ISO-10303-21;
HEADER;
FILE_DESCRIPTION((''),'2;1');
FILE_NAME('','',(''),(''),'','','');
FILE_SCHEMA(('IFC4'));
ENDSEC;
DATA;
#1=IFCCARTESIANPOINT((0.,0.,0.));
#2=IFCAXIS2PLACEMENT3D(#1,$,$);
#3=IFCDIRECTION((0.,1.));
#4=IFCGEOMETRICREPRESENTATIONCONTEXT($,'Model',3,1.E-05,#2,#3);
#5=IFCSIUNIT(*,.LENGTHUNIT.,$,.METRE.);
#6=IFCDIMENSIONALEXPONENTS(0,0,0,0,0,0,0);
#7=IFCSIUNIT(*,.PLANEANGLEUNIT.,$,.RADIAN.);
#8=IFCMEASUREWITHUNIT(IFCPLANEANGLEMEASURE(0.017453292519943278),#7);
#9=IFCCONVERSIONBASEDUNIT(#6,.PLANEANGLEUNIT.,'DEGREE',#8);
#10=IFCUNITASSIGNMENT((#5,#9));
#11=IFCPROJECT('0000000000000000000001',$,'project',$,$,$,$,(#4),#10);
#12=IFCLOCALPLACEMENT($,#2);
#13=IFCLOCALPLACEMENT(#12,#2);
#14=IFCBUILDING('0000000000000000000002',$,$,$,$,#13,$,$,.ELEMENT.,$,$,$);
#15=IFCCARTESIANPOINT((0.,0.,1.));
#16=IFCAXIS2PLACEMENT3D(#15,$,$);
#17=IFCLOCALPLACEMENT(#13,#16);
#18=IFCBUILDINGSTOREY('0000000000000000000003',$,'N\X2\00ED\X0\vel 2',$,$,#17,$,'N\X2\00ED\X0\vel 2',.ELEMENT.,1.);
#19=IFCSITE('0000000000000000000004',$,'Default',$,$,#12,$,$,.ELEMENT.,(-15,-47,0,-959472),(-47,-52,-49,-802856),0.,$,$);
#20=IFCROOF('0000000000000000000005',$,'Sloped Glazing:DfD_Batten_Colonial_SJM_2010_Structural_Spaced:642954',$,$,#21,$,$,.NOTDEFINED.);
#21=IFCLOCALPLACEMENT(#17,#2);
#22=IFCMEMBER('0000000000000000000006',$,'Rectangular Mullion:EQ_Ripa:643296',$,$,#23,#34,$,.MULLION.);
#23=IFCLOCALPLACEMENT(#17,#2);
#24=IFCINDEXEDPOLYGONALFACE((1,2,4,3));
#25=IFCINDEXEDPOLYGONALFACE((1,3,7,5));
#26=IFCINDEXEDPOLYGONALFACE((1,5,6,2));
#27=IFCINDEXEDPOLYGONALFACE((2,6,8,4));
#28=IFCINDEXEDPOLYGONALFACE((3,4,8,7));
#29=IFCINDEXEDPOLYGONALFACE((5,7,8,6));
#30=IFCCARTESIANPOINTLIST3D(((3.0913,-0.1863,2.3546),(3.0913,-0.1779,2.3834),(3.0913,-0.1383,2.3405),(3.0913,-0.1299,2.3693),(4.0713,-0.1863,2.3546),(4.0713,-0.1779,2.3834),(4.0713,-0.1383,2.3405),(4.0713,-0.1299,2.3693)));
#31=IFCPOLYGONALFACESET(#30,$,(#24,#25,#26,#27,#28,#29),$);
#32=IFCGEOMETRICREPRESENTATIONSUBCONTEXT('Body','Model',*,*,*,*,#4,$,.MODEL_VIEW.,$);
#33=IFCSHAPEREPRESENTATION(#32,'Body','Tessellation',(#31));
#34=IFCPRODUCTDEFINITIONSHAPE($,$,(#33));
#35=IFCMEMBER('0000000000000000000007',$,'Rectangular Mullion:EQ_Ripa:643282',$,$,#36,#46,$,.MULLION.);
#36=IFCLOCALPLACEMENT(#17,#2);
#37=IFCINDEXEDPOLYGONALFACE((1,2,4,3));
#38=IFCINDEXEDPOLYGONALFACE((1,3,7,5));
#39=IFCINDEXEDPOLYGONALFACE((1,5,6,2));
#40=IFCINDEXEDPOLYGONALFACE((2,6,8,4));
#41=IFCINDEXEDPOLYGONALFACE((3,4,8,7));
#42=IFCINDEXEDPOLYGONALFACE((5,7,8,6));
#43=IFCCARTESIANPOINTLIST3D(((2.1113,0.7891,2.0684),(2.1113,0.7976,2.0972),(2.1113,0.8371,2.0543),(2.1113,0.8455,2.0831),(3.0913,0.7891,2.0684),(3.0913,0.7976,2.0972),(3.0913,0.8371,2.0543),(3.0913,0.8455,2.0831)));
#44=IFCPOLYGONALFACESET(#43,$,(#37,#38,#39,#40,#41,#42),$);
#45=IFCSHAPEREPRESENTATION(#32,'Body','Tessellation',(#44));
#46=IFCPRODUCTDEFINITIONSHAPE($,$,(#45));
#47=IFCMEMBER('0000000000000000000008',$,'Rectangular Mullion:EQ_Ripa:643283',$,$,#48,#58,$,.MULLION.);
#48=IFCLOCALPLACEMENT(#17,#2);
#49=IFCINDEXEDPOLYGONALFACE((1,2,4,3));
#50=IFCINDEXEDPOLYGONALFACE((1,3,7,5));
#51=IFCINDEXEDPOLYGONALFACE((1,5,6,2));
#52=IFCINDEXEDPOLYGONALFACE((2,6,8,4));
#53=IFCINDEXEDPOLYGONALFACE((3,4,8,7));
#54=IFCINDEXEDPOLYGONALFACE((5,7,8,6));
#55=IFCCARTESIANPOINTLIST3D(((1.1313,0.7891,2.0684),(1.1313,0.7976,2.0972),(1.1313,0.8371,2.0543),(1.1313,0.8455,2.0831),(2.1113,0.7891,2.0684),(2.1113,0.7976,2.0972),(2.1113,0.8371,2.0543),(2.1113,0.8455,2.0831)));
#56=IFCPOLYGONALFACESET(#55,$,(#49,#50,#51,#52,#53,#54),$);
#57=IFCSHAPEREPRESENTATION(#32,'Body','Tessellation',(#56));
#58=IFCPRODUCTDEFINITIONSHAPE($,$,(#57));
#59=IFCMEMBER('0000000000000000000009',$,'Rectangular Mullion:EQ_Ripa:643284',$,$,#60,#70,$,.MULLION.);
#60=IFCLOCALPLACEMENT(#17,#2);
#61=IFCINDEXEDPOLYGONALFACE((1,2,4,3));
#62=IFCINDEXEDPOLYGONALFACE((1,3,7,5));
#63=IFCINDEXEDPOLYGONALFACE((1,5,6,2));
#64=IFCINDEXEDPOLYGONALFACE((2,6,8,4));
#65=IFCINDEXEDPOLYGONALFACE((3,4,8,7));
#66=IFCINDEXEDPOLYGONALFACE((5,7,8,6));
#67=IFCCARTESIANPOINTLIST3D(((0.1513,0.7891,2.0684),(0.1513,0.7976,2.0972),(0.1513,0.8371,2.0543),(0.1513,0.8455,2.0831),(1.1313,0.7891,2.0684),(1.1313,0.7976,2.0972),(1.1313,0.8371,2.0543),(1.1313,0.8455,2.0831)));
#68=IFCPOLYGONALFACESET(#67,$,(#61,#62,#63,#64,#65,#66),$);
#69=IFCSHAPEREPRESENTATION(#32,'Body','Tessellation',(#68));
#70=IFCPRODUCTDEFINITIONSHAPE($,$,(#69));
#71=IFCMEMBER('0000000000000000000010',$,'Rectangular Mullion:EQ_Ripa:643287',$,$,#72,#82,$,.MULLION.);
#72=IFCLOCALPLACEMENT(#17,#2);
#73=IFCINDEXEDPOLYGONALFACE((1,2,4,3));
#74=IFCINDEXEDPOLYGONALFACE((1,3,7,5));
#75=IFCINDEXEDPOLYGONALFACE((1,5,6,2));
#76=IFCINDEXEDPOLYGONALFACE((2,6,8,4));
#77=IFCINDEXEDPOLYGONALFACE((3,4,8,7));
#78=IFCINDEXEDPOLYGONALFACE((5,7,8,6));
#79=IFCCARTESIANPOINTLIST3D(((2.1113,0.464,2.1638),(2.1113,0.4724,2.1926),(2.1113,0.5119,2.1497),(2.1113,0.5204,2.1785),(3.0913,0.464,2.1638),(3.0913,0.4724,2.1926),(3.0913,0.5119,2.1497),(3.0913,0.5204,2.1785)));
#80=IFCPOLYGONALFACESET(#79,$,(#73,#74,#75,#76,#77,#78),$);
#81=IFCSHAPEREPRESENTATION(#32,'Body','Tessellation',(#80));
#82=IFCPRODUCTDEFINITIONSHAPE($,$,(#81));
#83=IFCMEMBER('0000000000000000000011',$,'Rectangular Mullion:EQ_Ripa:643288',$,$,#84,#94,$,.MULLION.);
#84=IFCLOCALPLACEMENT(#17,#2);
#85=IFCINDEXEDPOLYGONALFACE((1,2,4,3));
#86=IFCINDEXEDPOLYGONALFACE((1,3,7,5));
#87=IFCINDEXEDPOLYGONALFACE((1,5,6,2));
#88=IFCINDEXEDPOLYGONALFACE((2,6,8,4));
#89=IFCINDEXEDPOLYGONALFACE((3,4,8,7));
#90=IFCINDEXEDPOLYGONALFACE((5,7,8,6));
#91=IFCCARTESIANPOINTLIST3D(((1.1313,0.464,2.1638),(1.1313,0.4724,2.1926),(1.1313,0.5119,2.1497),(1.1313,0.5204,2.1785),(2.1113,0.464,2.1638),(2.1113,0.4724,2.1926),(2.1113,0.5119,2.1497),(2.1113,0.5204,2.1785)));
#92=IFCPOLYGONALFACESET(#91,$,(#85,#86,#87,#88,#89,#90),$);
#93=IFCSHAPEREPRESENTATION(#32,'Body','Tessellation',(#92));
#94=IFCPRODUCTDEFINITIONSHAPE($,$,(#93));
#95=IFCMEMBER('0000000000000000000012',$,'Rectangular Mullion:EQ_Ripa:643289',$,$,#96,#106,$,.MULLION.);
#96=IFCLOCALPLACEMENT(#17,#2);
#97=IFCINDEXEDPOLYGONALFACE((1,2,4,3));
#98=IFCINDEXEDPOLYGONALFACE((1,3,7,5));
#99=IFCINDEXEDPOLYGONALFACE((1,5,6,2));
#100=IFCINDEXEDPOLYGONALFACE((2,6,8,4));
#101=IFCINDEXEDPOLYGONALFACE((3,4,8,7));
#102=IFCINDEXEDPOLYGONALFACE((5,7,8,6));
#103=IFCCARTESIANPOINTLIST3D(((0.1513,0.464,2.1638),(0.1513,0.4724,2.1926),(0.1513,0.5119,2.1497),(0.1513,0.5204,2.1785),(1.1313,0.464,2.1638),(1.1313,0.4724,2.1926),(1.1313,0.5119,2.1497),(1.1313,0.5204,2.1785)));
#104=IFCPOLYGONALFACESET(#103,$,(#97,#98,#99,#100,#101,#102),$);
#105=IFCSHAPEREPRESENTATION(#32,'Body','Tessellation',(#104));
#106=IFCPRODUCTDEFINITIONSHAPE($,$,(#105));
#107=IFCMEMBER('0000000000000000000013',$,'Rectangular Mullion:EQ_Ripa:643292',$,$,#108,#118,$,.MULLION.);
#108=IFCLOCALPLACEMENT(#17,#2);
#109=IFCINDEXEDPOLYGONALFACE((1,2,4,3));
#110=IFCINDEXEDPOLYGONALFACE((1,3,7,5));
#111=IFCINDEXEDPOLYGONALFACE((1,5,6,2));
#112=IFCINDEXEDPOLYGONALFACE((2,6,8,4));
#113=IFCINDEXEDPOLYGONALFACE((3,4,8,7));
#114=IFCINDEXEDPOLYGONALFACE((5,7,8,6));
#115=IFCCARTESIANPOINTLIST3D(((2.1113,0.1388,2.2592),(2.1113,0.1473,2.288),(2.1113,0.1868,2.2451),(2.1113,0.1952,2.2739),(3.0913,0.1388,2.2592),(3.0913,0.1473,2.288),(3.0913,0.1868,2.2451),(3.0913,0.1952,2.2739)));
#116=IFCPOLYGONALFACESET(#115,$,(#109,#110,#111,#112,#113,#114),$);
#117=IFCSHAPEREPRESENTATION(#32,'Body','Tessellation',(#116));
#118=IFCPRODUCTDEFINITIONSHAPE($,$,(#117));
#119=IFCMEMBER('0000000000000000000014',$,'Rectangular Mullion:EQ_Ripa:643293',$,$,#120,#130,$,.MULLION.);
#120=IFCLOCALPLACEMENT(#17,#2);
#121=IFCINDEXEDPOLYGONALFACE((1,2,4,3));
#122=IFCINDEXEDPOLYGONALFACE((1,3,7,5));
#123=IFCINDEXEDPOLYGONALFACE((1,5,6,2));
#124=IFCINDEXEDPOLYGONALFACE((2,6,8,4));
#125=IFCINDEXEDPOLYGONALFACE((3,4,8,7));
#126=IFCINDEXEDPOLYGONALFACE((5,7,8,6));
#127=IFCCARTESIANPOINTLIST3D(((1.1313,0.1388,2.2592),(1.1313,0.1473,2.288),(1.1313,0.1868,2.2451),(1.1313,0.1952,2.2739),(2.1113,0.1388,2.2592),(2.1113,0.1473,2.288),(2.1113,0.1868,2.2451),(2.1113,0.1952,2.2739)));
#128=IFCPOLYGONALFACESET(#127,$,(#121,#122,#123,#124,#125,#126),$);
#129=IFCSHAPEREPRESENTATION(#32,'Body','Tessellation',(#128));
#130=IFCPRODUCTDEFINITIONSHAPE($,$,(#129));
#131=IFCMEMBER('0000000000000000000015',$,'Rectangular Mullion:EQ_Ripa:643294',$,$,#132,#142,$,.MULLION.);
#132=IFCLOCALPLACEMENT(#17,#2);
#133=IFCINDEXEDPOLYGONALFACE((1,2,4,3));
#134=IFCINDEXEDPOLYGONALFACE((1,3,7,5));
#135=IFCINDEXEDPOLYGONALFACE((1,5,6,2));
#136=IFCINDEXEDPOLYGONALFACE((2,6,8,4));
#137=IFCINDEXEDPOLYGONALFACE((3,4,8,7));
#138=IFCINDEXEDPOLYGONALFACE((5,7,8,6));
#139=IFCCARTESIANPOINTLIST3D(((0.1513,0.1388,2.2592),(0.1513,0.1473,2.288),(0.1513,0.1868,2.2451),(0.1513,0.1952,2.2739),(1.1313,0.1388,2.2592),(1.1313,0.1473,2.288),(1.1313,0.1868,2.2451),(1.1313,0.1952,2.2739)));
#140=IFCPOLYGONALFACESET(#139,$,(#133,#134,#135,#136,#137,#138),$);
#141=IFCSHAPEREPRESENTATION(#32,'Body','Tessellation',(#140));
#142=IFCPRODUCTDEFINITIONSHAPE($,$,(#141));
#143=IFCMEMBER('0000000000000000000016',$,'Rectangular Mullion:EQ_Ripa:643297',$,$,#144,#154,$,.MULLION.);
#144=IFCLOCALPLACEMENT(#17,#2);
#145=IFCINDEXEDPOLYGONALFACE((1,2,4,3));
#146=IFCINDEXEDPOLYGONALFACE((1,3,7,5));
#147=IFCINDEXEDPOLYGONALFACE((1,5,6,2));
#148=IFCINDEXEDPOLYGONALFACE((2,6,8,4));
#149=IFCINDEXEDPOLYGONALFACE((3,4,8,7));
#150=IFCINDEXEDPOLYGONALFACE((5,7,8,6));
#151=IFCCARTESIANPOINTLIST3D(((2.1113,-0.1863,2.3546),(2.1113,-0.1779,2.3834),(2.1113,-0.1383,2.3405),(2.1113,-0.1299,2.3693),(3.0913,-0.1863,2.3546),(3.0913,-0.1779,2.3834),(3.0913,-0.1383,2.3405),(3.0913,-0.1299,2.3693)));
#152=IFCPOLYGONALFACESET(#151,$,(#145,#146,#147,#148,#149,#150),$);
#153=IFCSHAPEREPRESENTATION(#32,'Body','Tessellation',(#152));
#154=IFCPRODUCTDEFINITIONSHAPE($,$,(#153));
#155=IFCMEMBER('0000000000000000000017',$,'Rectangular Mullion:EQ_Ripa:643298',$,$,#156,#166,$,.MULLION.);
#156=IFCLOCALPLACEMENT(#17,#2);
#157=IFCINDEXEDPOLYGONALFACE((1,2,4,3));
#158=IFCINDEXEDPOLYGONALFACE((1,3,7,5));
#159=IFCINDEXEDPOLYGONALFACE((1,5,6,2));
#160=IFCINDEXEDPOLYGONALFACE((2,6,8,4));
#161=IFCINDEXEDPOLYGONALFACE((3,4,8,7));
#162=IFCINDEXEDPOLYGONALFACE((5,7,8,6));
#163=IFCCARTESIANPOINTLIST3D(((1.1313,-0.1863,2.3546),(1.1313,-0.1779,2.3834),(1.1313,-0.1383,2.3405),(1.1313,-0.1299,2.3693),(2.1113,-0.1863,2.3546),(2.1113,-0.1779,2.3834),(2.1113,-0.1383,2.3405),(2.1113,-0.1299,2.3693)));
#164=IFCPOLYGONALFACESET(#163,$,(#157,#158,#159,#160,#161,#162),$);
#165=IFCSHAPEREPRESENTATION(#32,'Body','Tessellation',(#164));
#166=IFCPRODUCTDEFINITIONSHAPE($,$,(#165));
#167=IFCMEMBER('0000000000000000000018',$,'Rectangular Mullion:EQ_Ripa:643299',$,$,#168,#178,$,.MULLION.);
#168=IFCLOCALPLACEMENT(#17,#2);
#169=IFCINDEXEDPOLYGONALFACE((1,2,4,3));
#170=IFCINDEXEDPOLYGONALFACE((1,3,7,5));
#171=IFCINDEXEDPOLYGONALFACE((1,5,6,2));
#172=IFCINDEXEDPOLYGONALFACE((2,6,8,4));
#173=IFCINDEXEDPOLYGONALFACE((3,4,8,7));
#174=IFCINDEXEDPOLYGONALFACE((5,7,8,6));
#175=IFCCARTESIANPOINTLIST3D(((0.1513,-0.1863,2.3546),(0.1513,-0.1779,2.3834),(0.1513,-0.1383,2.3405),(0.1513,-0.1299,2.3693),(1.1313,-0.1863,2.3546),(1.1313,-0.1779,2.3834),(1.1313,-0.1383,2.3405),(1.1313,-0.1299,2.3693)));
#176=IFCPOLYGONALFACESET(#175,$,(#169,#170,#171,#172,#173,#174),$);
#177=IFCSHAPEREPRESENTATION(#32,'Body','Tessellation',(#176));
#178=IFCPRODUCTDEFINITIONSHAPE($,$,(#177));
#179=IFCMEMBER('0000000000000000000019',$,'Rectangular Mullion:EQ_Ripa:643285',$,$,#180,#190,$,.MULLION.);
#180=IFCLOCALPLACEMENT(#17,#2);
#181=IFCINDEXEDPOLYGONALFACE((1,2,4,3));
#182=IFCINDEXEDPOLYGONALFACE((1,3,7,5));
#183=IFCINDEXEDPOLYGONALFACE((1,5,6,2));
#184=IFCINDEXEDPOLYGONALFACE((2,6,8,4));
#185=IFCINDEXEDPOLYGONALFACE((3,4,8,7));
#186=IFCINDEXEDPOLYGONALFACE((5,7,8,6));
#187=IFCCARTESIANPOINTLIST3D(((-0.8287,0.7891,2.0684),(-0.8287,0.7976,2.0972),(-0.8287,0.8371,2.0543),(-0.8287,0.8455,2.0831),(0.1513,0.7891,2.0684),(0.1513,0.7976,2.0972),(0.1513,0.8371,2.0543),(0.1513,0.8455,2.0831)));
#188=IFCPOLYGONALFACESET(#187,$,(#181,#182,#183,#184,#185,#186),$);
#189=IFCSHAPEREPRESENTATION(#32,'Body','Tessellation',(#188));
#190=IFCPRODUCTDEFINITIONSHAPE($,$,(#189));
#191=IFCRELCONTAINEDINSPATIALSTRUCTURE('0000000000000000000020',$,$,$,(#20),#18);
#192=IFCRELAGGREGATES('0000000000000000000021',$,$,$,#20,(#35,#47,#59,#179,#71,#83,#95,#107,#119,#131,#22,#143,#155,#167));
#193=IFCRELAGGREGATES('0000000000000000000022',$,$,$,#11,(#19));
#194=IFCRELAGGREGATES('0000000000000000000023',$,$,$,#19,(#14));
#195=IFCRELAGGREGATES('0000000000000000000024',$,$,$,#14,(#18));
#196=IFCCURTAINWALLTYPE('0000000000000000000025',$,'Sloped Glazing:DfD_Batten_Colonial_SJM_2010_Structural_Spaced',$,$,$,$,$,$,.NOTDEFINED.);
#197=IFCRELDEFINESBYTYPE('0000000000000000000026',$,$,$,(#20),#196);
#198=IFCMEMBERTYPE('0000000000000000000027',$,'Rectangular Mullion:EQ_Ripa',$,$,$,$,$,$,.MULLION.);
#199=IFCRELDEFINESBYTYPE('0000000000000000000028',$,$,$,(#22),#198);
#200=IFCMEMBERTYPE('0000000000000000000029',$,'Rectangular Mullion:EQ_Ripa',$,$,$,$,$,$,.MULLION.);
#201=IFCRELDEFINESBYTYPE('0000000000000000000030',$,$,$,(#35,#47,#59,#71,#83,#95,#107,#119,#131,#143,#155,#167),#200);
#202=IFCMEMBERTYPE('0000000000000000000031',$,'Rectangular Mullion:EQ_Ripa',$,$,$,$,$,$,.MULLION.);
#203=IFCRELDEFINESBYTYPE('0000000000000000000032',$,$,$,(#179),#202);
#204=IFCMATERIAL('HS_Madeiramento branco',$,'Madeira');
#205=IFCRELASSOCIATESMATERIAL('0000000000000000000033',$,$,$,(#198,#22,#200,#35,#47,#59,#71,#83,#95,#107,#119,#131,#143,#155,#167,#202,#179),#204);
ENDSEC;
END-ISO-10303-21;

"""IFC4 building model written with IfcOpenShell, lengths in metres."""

from ifc_helpers import new_model, entity, si_unit, converted_unit, direction, frame, origin, place, context, subcontext, project, spatial, indexed_curve, outline, extrude, source, transform, mapped, material, type_object, type_shapes, element, aggregate, save


model = new_model("IFC4")

# Units and contexts
model_context = context("Model", 3, precision=1e-05, world=origin(), true_north=direction((0.0, 1.0)))
body_context = subcontext(model_context, "Body", "Model", "MODEL_VIEW")
ifc_project = project(units=[si_unit("LENGTHUNIT", "METRE"), converted_unit("PLANEANGLEUNIT", "DEGREE", entity("IfcPlaneAngleMeasure", 0.017453292519943278), si_unit("PLANEANGLEUNIT", "RADIAN"), dimensions=[0, 0, 0, 0, 0, 0, 0])], contexts=[model_context])

# Site, building, storey
site_placement = place(None, origin())
site = spatial("IfcSite", under=ifc_project, at=site_placement, Name="Default", CompositionType="ELEMENT", RefLatitude=(-15, -47, 0, -959472), RefLongitude=(-47, -52, -49, -802856), RefElevation=0.0)
building_placement = place(site_placement, origin())
building = spatial("IfcBuilding", under=site, at=building_placement, CompositionType="ELEMENT")
storey_placement = place(building_placement, frame((0.0, 0.0, 1.0)))
storey = spatial("IfcBuildingStorey", under=building, at=storey_placement, Name="Nível 2", LongName="Nível 2", CompositionType="ELEMENT", Elevation=1.0)

# Roof, members
curtain_wall_type = type_object("IfcCurtainWallType", Name="Sloped Glazing:DfD_Batten_Colonial_SJM_2010_Structural_Spaced", PredefinedType="NOTDEFINED")
roof_placement = place(storey_placement, frame((0.0, 0.0, -1.0)))
roof = element("IfcRoof", 1, at=roof_placement, inside=storey, type_object=curtain_wall_type, Name="Sloped Glazing:DfD_Batten_Colonial_SJM_2010_Structural_Spaced:642954", PredefinedType="NOTDEFINED")
ifc_material_1 = material(Name="HS_Madeiramento branco", Category="Madeira")
member_type_1 = type_object("IfcMemberType", Name="Rectangular Mullion:EQ_Ripa", PredefinedType="MULLION", material=ifc_material_1)
shared_shape_1 = source(origin(), body_context, "Body", "SweptSolid", [
    extrude(outline(indexed_curve([(-0.025, -0.015), (0.025, -0.015), (0.025, 0.015), (-0.025, 0.015), (-0.025, -0.015)], self_intersect=False)), frame((0.0, 0.0, -0.98), z_axis=(0.0, 0.0, 1.0), x_axis=(-1.0, 0.0, 0.0)), (0.0, 0.0, 1.0), 0.98),
])
type_shapes(member_type_1, [shared_shape_1])
member_1_placement = place(roof_placement, frame((4.0713, -0.1581, 3.3619), z_axis=(1.0, 0.0, 0.0), x_axis=(0.0, -0.95956, 0.281504)))
member_1 = element("IfcMember", 2, at=member_1_placement, type_object=member_type_1, material=ifc_material_1, Name="Rectangular Mullion:EQ_Ripa:643296", PredefinedType="MULLION", context=body_context, shape_type="MappedRepresentation", body=[
    mapped(shared_shape_1, transform((0.0, 0.0, 0.0), scale=1.0)),
])
member_type_2 = type_object("IfcMemberType", Name="Rectangular Mullion:EQ_Ripa", PredefinedType="MULLION", material=ifc_material_1)
shared_shape_2 = source(origin(), body_context, "Body", "SweptSolid", [
    extrude(outline(indexed_curve([(-0.025, -0.015), (0.025, -0.015), (0.025, 0.015), (-0.025, 0.015), (-0.025, -0.015)], self_intersect=False)), frame((0.0, 0.0, -0.98), z_axis=(0.0, 0.0, 1.0), x_axis=(-1.0, 0.0, 0.0)), (0.0, 0.0, 1.0), 0.98),
])
type_shapes(member_type_2, [shared_shape_2])
member_2_placement = place(roof_placement, frame((3.0913, 0.8173, 3.0758), z_axis=(1.0, 0.0, 0.0), x_axis=(0.0, -0.95956, 0.281504)))
member_2 = element("IfcMember", 3, at=member_2_placement, type_object=member_type_2, material=ifc_material_1, Name="Rectangular Mullion:EQ_Ripa:643282", PredefinedType="MULLION", context=body_context, shape_type="MappedRepresentation", body=[
    mapped(shared_shape_2, transform((0.0, 0.0, 0.0), scale=1.0)),
])
member_3_placement = place(roof_placement, frame((2.1113, 0.8173, 3.0758), z_axis=(1.0, 0.0, 0.0), x_axis=(0.0, -0.95956, 0.281504)))
member_3 = element("IfcMember", 4, at=member_3_placement, type_object=member_type_2, material=ifc_material_1, Name="Rectangular Mullion:EQ_Ripa:643283", PredefinedType="MULLION", context=body_context, shape_type="MappedRepresentation", body=[
    mapped(shared_shape_2, transform((0.0, 0.0, 0.0), scale=1.0)),
])
member_4_placement = place(roof_placement, frame((1.1313, 0.8173, 3.0758), z_axis=(1.0, 0.0, 0.0), x_axis=(0.0, -0.95956, 0.281504)))
member_4 = element("IfcMember", 5, at=member_4_placement, type_object=member_type_2, material=ifc_material_1, Name="Rectangular Mullion:EQ_Ripa:643284", PredefinedType="MULLION", context=body_context, shape_type="MappedRepresentation", body=[
    mapped(shared_shape_2, transform((0.0, 0.0, 0.0), scale=1.0)),
])
member_5_placement = place(roof_placement, frame((3.0913, 0.4922, 3.1712), z_axis=(1.0, 0.0, 0.0), x_axis=(0.0, -0.95956, 0.281504)))
member_5 = element("IfcMember", 6, at=member_5_placement, type_object=member_type_2, material=ifc_material_1, Name="Rectangular Mullion:EQ_Ripa:643287", PredefinedType="MULLION", context=body_context, shape_type="MappedRepresentation", body=[
    mapped(shared_shape_2, transform((0.0, 0.0, 0.0), scale=1.0)),
])
member_6_placement = place(roof_placement, frame((2.1113, 0.4922, 3.1712), z_axis=(1.0, 0.0, 0.0), x_axis=(0.0, -0.95956, 0.281504)))
member_6 = element("IfcMember", 7, at=member_6_placement, type_object=member_type_2, material=ifc_material_1, Name="Rectangular Mullion:EQ_Ripa:643288", PredefinedType="MULLION", context=body_context, shape_type="MappedRepresentation", body=[
    mapped(shared_shape_2, transform((0.0, 0.0, 0.0), scale=1.0)),
])
member_7_placement = place(roof_placement, frame((1.1313, 0.4922, 3.1712), z_axis=(1.0, 0.0, 0.0), x_axis=(0.0, -0.95956, 0.281504)))
member_7 = element("IfcMember", 8, at=member_7_placement, type_object=member_type_2, material=ifc_material_1, Name="Rectangular Mullion:EQ_Ripa:643289", PredefinedType="MULLION", context=body_context, shape_type="MappedRepresentation", body=[
    mapped(shared_shape_2, transform((0.0, 0.0, 0.0), scale=1.0)),
])
member_8_placement = place(roof_placement, frame((3.0913, 0.167, 3.2665), z_axis=(1.0, 0.0, 0.0), x_axis=(0.0, -0.95956, 0.281504)))
member_8 = element("IfcMember", 9, at=member_8_placement, type_object=member_type_2, material=ifc_material_1, Name="Rectangular Mullion:EQ_Ripa:643292", PredefinedType="MULLION", context=body_context, shape_type="MappedRepresentation", body=[
    mapped(shared_shape_2, transform((0.0, 0.0, 0.0), scale=1.0)),
])
member_9_placement = place(roof_placement, frame((2.1113, 0.167, 3.2665), z_axis=(1.0, 0.0, 0.0), x_axis=(0.0, -0.95956, 0.281504)))
member_9 = element("IfcMember", 10, at=member_9_placement, type_object=member_type_2, material=ifc_material_1, Name="Rectangular Mullion:EQ_Ripa:643293", PredefinedType="MULLION", context=body_context, shape_type="MappedRepresentation", body=[
    mapped(shared_shape_2, transform((0.0, 0.0, 0.0), scale=1.0)),
])
member_10_placement = place(roof_placement, frame((1.1313, 0.167, 3.2665), z_axis=(1.0, 0.0, 0.0), x_axis=(0.0, -0.95956, 0.281504)))
member_10 = element("IfcMember", 11, at=member_10_placement, type_object=member_type_2, material=ifc_material_1, Name="Rectangular Mullion:EQ_Ripa:643294", PredefinedType="MULLION", context=body_context, shape_type="MappedRepresentation", body=[
    mapped(shared_shape_2, transform((0.0, 0.0, 0.0), scale=1.0)),
])
member_11_placement = place(roof_placement, frame((3.0913, -0.1581, 3.3619), z_axis=(1.0, 0.0, 0.0), x_axis=(0.0, -0.95956, 0.281504)))
member_11 = element("IfcMember", 12, at=member_11_placement, type_object=member_type_2, material=ifc_material_1, Name="Rectangular Mullion:EQ_Ripa:643297", PredefinedType="MULLION", context=body_context, shape_type="MappedRepresentation", body=[
    mapped(shared_shape_2, transform((0.0, 0.0, 0.0), scale=1.0)),
])
member_12_placement = place(roof_placement, frame((2.1113, -0.1581, 3.3619), z_axis=(1.0, 0.0, 0.0), x_axis=(0.0, -0.95956, 0.281504)))
member_12 = element("IfcMember", 13, at=member_12_placement, type_object=member_type_2, material=ifc_material_1, Name="Rectangular Mullion:EQ_Ripa:643298", PredefinedType="MULLION", context=body_context, shape_type="MappedRepresentation", body=[
    mapped(shared_shape_2, transform((0.0, 0.0, 0.0), scale=1.0)),
])
member_13_placement = place(roof_placement, frame((1.1313, -0.1581, 3.3619), z_axis=(1.0, 0.0, 0.0), x_axis=(0.0, -0.95956, 0.281504)))
member_13 = element("IfcMember", 14, at=member_13_placement, type_object=member_type_2, material=ifc_material_1, Name="Rectangular Mullion:EQ_Ripa:643299", PredefinedType="MULLION", context=body_context, shape_type="MappedRepresentation", body=[
    mapped(shared_shape_2, transform((0.0, 0.0, 0.0), scale=1.0)),
])
member_type_3 = type_object("IfcMemberType", Name="Rectangular Mullion:EQ_Ripa", PredefinedType="MULLION", material=ifc_material_1)
shared_shape_3 = source(origin(), body_context, "Body", "SweptSolid", [
    extrude(outline(indexed_curve([(-0.025, -0.015), (0.025, -0.015), (0.025, 0.015), (-0.025, 0.015), (-0.025, -0.015)], self_intersect=False)), frame((0.0, 0.0, -0.98), z_axis=(0.0, 0.0, 1.0), x_axis=(-1.0, 0.0, 0.0)), (0.0, 0.0, 1.0), 0.98),
])
type_shapes(member_type_3, [shared_shape_3])
member_14_placement = place(roof_placement, frame((0.1513, 0.8173, 3.0758), z_axis=(1.0, 0.0, 0.0), x_axis=(0.0, -0.95956, 0.281504)))
member_14 = element("IfcMember", 15, at=member_14_placement, type_object=member_type_3, material=ifc_material_1, Name="Rectangular Mullion:EQ_Ripa:643285", PredefinedType="MULLION", context=body_context, shape_type="MappedRepresentation", body=[
    mapped(shared_shape_3, transform((0.0, 0.0, 0.0), scale=1.0)),
])
aggregate(roof, [member_2, member_3, member_4, member_14, member_5, member_6, member_7, member_8, member_9, member_10, member_1, member_11, member_12, member_13])

save(model, "model.ifc")
